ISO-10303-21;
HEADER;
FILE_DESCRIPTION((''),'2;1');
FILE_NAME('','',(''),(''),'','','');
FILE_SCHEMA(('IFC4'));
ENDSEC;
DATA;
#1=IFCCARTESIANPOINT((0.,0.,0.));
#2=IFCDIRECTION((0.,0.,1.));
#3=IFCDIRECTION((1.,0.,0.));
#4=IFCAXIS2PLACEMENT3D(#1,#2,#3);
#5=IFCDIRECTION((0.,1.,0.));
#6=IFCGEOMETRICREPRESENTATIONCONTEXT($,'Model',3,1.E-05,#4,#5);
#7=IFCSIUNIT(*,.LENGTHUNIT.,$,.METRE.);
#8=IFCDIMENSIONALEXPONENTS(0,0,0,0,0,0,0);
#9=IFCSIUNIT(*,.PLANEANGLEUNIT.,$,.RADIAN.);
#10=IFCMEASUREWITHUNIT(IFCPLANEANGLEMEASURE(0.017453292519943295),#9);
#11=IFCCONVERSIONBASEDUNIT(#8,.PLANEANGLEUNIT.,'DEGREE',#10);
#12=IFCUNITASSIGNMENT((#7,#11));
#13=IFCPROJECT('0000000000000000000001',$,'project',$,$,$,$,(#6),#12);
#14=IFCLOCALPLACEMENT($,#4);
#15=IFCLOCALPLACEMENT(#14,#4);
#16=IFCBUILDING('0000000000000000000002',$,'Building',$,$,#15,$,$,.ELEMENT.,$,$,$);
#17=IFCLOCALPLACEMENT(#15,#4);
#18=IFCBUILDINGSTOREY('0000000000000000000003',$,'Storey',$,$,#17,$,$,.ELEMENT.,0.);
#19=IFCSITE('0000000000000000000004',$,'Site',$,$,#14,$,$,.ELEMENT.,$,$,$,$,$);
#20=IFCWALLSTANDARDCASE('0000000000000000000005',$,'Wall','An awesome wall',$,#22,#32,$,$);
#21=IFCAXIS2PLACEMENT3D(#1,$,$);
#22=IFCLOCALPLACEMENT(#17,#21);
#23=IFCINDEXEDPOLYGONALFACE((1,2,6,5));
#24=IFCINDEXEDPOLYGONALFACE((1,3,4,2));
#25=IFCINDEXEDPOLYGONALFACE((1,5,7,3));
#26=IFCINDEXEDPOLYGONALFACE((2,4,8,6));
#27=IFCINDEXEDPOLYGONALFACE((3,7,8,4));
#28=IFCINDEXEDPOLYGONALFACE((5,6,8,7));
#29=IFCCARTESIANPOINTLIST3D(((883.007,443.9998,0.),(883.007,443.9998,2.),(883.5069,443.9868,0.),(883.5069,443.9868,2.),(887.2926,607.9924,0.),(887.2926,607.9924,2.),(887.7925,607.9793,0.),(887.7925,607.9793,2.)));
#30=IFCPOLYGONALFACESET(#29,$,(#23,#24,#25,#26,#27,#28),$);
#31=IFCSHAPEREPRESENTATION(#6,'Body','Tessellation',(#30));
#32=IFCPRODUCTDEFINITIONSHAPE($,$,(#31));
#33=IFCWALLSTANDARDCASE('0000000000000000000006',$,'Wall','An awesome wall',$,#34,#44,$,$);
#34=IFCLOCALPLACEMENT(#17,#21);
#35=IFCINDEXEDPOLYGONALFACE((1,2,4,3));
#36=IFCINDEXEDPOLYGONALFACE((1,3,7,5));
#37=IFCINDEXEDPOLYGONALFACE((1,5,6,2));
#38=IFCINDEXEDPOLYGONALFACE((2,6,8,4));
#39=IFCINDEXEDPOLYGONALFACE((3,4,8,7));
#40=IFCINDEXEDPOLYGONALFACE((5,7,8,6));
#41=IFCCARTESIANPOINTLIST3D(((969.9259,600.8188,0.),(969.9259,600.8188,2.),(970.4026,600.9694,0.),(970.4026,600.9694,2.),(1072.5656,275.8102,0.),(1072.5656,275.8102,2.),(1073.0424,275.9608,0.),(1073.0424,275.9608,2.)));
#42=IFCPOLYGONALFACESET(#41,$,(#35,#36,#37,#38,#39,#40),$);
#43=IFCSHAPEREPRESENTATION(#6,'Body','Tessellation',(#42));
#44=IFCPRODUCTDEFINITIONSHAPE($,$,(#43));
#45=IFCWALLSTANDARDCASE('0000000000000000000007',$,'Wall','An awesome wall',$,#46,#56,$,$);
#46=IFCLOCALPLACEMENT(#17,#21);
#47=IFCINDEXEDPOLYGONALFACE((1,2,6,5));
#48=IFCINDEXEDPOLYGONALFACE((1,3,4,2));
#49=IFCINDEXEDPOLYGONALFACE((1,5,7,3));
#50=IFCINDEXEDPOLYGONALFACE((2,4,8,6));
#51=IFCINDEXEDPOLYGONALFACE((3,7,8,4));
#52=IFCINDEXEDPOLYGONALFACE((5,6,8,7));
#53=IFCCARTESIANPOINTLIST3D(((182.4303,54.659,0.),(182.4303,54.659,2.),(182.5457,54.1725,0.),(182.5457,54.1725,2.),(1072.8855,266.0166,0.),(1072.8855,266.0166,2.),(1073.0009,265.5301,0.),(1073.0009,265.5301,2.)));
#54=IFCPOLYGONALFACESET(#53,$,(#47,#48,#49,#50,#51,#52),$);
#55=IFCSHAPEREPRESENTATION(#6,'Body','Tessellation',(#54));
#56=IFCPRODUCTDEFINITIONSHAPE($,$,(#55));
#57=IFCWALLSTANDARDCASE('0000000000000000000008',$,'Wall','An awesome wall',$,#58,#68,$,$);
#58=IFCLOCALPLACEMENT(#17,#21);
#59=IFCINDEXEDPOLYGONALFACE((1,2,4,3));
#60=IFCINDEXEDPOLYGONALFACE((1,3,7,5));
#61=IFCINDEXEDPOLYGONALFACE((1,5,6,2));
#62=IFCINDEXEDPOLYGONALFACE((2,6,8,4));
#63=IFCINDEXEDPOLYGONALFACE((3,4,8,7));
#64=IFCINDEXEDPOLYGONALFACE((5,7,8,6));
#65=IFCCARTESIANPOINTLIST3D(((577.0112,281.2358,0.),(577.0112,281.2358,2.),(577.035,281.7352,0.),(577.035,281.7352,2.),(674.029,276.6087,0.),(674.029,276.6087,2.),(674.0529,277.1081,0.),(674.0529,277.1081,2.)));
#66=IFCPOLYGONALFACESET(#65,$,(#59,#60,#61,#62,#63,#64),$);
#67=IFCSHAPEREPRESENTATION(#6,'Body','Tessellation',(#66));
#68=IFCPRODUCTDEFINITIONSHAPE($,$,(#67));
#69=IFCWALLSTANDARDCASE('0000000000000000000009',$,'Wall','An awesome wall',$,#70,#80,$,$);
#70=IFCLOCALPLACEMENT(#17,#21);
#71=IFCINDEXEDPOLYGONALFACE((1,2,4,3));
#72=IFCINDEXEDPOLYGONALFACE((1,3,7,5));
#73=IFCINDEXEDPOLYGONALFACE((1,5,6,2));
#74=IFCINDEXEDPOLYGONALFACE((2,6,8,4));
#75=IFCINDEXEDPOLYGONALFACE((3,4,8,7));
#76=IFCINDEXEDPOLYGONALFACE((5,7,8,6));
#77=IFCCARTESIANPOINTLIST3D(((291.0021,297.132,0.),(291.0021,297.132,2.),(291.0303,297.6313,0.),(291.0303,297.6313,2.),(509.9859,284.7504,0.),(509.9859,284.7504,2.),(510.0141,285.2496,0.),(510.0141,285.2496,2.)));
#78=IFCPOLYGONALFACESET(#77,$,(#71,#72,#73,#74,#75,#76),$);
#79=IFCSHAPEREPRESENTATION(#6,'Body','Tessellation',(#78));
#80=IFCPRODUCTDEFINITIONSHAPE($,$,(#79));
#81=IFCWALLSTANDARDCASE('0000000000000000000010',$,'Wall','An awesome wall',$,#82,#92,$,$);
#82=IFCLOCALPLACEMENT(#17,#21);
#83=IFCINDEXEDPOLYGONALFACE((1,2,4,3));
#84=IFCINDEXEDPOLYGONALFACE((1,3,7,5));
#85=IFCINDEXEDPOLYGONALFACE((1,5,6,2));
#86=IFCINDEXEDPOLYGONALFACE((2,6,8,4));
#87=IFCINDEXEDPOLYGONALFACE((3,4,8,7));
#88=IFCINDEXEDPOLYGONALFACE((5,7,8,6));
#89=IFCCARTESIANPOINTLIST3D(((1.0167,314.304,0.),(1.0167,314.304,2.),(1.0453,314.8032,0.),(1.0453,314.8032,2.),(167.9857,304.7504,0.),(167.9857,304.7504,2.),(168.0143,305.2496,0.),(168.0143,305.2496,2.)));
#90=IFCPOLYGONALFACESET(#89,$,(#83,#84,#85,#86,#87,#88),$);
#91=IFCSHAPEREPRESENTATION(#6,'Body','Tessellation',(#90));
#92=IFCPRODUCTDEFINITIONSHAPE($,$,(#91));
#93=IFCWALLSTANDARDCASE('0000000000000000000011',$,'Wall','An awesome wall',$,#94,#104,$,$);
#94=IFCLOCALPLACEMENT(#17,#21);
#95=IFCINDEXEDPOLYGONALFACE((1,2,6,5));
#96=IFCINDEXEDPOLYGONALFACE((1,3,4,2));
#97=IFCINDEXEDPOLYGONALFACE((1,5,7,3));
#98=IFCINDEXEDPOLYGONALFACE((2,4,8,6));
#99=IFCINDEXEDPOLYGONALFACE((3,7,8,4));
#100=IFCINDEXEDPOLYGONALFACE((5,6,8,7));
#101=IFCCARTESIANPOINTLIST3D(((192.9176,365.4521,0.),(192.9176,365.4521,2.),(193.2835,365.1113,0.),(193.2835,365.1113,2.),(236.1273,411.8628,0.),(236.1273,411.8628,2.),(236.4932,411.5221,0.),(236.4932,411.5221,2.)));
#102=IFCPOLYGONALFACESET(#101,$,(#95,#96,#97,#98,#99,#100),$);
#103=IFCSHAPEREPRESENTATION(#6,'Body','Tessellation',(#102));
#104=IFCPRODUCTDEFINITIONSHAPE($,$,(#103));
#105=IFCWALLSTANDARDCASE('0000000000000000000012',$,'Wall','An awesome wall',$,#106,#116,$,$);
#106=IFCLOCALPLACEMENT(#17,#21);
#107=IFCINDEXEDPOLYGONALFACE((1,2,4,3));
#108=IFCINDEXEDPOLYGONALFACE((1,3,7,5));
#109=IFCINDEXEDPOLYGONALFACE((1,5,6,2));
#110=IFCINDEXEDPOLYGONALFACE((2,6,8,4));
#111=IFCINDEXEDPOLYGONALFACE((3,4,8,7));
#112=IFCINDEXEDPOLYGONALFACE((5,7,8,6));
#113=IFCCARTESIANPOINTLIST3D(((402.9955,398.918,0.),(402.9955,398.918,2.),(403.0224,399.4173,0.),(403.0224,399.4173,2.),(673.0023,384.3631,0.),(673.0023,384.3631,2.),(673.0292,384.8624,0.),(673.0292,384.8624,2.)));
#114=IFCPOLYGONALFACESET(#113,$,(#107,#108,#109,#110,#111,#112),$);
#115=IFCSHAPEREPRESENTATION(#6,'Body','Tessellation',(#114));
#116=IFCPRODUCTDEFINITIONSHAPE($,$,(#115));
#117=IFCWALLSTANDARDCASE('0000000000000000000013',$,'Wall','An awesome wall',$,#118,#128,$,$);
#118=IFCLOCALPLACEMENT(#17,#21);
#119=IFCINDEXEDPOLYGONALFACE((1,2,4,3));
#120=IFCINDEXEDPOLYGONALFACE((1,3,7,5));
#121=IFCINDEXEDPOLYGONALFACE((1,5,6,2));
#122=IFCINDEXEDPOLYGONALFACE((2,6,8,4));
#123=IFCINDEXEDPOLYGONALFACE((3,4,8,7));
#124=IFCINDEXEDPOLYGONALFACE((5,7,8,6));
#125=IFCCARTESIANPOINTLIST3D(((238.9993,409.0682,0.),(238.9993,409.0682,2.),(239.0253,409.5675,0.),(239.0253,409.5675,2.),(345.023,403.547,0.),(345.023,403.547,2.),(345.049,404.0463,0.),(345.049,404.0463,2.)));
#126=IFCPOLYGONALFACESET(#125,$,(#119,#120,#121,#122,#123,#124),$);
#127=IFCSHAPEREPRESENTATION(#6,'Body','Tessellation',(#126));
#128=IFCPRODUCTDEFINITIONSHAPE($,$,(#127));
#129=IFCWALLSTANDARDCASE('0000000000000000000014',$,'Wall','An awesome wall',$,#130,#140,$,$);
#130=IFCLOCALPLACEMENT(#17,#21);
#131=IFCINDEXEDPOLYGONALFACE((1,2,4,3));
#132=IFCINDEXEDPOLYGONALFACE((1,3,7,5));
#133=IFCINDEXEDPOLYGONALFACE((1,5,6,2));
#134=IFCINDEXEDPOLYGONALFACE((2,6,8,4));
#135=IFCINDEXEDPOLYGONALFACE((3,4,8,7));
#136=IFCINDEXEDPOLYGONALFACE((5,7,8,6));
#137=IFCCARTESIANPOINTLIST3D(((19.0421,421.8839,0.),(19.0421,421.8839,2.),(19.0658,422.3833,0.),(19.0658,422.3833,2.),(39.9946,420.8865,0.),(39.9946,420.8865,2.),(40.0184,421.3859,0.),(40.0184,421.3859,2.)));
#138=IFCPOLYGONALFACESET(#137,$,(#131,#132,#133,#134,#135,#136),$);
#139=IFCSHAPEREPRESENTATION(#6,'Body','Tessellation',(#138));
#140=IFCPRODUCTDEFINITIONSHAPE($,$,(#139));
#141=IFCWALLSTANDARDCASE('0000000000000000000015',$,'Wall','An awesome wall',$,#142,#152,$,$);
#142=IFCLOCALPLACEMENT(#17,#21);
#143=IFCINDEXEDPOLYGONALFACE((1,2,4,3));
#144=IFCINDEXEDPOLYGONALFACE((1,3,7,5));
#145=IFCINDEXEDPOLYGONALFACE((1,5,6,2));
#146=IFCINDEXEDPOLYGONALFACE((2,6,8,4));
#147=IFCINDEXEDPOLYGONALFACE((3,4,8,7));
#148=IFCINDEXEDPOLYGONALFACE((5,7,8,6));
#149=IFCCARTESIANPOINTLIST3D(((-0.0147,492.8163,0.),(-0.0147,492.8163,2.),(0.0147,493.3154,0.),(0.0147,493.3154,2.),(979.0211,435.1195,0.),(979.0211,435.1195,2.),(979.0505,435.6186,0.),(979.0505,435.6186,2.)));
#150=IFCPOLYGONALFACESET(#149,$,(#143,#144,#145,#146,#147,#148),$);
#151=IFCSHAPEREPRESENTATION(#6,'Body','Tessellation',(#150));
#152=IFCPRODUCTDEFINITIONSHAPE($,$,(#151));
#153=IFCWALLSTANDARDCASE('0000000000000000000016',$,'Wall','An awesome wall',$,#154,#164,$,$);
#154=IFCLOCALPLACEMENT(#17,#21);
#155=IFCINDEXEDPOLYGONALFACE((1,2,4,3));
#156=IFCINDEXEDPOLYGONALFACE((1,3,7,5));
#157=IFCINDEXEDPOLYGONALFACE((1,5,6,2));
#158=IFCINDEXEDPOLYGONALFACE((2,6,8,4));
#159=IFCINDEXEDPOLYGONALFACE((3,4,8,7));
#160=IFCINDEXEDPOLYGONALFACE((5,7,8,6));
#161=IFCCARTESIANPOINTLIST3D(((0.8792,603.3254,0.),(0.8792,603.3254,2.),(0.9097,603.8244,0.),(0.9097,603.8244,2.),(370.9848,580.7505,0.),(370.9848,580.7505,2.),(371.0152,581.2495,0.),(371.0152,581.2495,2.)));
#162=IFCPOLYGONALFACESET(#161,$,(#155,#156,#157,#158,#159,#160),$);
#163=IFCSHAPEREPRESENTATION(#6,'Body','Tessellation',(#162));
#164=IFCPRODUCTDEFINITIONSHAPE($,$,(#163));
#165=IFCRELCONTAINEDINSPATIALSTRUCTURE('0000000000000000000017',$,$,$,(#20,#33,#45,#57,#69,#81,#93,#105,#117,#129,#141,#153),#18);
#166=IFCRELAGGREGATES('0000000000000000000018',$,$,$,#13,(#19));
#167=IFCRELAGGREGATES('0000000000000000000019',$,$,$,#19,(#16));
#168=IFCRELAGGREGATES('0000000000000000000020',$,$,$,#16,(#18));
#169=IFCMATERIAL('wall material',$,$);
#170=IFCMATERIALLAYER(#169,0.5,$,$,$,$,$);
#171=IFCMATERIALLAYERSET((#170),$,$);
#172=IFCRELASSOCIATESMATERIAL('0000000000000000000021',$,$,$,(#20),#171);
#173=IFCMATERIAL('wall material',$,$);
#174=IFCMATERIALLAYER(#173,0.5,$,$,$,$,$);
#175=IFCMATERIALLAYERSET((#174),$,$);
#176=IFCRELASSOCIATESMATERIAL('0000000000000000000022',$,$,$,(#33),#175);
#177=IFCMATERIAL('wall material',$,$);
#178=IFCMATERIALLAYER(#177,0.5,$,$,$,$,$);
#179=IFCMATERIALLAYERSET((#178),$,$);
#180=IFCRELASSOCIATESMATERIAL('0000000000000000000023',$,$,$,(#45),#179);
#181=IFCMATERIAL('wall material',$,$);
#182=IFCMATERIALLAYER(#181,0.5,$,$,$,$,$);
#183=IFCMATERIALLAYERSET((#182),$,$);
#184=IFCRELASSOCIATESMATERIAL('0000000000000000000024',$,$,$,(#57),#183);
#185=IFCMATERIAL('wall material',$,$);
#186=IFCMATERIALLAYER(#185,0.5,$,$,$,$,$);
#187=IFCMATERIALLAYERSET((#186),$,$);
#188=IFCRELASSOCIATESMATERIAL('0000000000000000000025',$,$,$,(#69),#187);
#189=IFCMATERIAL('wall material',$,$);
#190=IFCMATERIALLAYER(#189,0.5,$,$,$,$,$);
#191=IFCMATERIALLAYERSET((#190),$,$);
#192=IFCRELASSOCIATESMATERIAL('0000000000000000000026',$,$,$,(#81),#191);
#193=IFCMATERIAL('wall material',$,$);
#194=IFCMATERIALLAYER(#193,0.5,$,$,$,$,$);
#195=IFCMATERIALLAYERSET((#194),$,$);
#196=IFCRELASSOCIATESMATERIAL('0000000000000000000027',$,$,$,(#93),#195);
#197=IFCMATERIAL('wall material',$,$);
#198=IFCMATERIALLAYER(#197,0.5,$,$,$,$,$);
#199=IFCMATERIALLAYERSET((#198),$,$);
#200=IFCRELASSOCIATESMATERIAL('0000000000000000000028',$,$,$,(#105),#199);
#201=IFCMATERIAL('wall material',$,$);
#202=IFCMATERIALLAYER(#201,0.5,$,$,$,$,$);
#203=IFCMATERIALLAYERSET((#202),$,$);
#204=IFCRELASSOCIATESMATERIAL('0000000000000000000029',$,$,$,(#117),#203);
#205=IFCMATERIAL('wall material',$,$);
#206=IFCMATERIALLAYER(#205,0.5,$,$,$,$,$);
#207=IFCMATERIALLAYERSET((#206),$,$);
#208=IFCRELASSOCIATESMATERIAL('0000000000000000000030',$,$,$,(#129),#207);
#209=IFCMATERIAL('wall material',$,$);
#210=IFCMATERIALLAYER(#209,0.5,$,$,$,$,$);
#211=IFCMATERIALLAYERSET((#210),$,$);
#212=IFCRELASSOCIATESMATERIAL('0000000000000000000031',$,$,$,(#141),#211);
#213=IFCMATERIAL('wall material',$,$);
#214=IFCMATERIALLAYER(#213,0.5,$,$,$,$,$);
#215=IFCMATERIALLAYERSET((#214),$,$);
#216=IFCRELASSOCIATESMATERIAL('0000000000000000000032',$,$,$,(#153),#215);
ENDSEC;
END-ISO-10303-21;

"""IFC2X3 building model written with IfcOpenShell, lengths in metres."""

from ifc_helpers import new_model, entity, si_unit, converted_unit, direction, frame, origin_with_axes, place, context, project, spatial, polyline, outline, extrude, material, layer, layer_set, layer_usage, element, save


model = new_model("IFC2X3")

# Units and contexts
model_context = context("Model", 3, precision=1e-05, world=origin_with_axes(), true_north=direction((0.0, 1.0, 0.0)))
ifc_project = project(units=[si_unit("LENGTHUNIT", "METRE"), converted_unit("PLANEANGLEUNIT", "DEGREE", entity("IfcPlaneAngleMeasure", 0.017453292519943295), si_unit("PLANEANGLEUNIT", "RADIAN"), dimensions=[0, 0, 0, 0, 0, 0, 0])], contexts=[model_context])

# Site, building, storey
site_placement = place(None, origin_with_axes())
site = spatial("IfcSite", under=ifc_project, at=site_placement, Name="Site", CompositionType="ELEMENT")
building_placement = place(site_placement, origin_with_axes())
building = spatial("IfcBuilding", under=site, at=building_placement, Name="Building", CompositionType="ELEMENT")
storey_placement = place(building_placement, origin_with_axes())
storey = spatial("IfcBuildingStorey", under=building, at=storey_placement, Name="Storey", CompositionType="ELEMENT", Elevation=0.0)

# Walls
ifc_material_1 = material(Name="wall material")
ifc_layer_1 = layer(ifc_material_1, 0.5)
ifc_layer_set_1 = layer_set([ifc_layer_1])
ifc_layer_usage_1 = layer_usage(ifc_layer_set_1, "AXIS2", "POSITIVE", -0.1)
wall_1_placement = place(storey_placement, origin_with_axes())
element("IfcWallStandardCase", 1, at=wall_1_placement, inside=storey, material=ifc_layer_usage_1, Name="Wall", Description="An awesome wall", context=model_context, shape_type="SweptSolid", body=[
    extrude(outline(polyline([(0.0, -0.25, 0.0), (164.0485, -0.25, 0.0), (164.0485, 0.25, 0.0), (0.0, 0.25, 0.0), (0.0, -0.25, 0.0)])), frame((883.257, 443.9933, 0.0), z_axis=(0.0, 0.0, 1.0), x_axis=(4.28558, 163.99254, 0.0)), (0.0, 0.0, 1.0), 2.0),
])
ifc_material_2 = material(Name="wall material")
ifc_layer_2 = layer(ifc_material_2, 0.5)
ifc_layer_set_2 = layer_set([ifc_layer_2])
ifc_layer_usage_2 = layer_usage(ifc_layer_set_2, "AXIS2", "POSITIVE", -0.1)
wall_2_placement = place(storey_placement, origin_with_axes())
element("IfcWallStandardCase", 2, at=wall_2_placement, inside=storey, material=ifc_layer_usage_2, Name="Wall", Description="An awesome wall", context=model_context, shape_type="SweptSolid", body=[
    extrude(outline(polyline([(0.0, -0.25, 0.0), (340.8306, -0.25, 0.0), (340.8306, 0.25, 0.0), (0.0, 0.25, 0.0), (0.0, -0.25, 0.0)])), frame((1072.804, 275.8855, 0.0), z_axis=(0.0, 0.0, 1.0), x_axis=(-102.63975, 325.00857, 0.0)), (0.0, 0.0, 1.0), 2.0),
])
ifc_material_3 = material(Name="wall material")
ifc_layer_3 = layer(ifc_material_3, 0.5)
ifc_layer_set_3 = layer_set([ifc_layer_3])
ifc_layer_usage_3 = layer_usage(ifc_layer_set_3, "AXIS2", "POSITIVE", -0.1)
wall_3_placement = place(storey_placement, origin_with_axes())
element("IfcWallStandardCase", 3, at=wall_3_placement, inside=storey, material=ifc_layer_usage_3, Name="Wall", Description="An awesome wall", context=model_context, shape_type="SweptSolid", body=[
    extrude(outline(polyline([(0.0, -0.25, 0.0), (915.1953, -0.25, 0.0), (915.1953, 0.25, 0.0), (0.0, 0.25, 0.0), (0.0, -0.25, 0.0)])), frame((182.488, 54.4158, 0.0), z_axis=(0.0, 0.0, 1.0), x_axis=(890.4552, 211.35757, 0.0)), (0.0, 0.0, 1.0), 2.0),
])
ifc_material_4 = material(Name="wall material")
ifc_layer_4 = layer(ifc_material_4, 0.5)
ifc_layer_set_4 = layer_set([ifc_layer_4])
ifc_layer_usage_4 = layer_usage(ifc_layer_set_4, "AXIS2", "POSITIVE", -0.1)
wall_4_placement = place(storey_placement, origin_with_axes())
element("IfcWallStandardCase", 4, at=wall_4_placement, inside=storey, material=ifc_layer_usage_4, Name="Wall", Description="An awesome wall", context=model_context, shape_type="SweptSolid", body=[
    extrude(outline(polyline([(0.0, -0.25, 0.0), (97.1281, -0.25, 0.0), (97.1281, 0.25, 0.0), (0.0, 0.25, 0.0), (0.0, -0.25, 0.0)])), frame((674.0409, 276.8584, 0.0), z_axis=(0.0, 0.0, 1.0), x_axis=(-97.01782, 4.62707, 0.0)), (0.0, 0.0, 1.0), 2.0),
])
ifc_material_5 = material(Name="wall material")
ifc_layer_5 = layer(ifc_material_5, 0.5)
ifc_layer_set_5 = layer_set([ifc_layer_5])
ifc_layer_usage_5 = layer_usage(ifc_layer_set_5, "AXIS2", "POSITIVE", -0.1)
wall_5_placement = place(storey_placement, origin_with_axes())
element("IfcWallStandardCase", 5, at=wall_5_placement, inside=storey, material=ifc_layer_usage_5, Name="Wall", Description="An awesome wall", context=model_context, shape_type="SweptSolid", body=[
    extrude(outline(polyline([(0.0, -0.25, 0.0), (219.3336, -0.25, 0.0), (219.3336, 0.25, 0.0), (0.0, 0.25, 0.0), (0.0, -0.25, 0.0)])), frame((510.0, 285.0, 0.0), z_axis=(0.0, 0.0, 1.0), x_axis=(-218.9838, 12.38165, 0.0)), (0.0, 0.0, 1.0), 2.0),
])
ifc_material_6 = material(Name="wall material")
ifc_layer_6 = layer(ifc_material_6, 0.5)
ifc_layer_set_6 = layer_set([ifc_layer_6])
ifc_layer_usage_6 = layer_usage(ifc_layer_set_6, "AXIS2", "POSITIVE", -0.1)
wall_6_placement = place(storey_placement, origin_with_axes())
element("IfcWallStandardCase", 6, at=wall_6_placement, inside=storey, material=ifc_layer_usage_6, Name="Wall", Description="An awesome wall", context=model_context, shape_type="SweptSolid", body=[
    extrude(outline(polyline([(0.0, -0.25, 0.0), (167.2421, -0.25, 0.0), (167.2421, 0.25, 0.0), (0.0, 0.25, 0.0), (0.0, -0.25, 0.0)])), frame((168.0, 305.0, 0.0), z_axis=(0.0, 0.0, 1.0), x_axis=(-166.96902, 9.55356, 0.0)), (0.0, 0.0, 1.0), 2.0),
])
ifc_material_7 = material(Name="wall material")
ifc_layer_7 = layer(ifc_material_7, 0.5)
ifc_layer_set_7 = layer_set([ifc_layer_7])
ifc_layer_usage_7 = layer_usage(ifc_layer_set_7, "AXIS2", "POSITIVE", -0.1)
wall_7_placement = place(storey_placement, origin_with_axes())
element("IfcWallStandardCase", 7, at=wall_7_placement, inside=storey, material=ifc_layer_usage_7, Name="Wall", Description="An awesome wall", context=model_context, shape_type="SweptSolid", body=[
    extrude(outline(polyline([(0.0, -0.25, 0.0), (63.4116, -0.25, 0.0), (63.4116, 0.25, 0.0), (0.0, 0.25, 0.0), (0.0, -0.25, 0.0)])), frame((193.1006, 365.2817, 0.0), z_axis=(0.0, 0.0, 1.0), x_axis=(43.20971, 46.41074, 0.0)), (0.0, 0.0, 1.0), 2.0),
])
ifc_material_8 = material(Name="wall material")
ifc_layer_8 = layer(ifc_material_8, 0.5)
ifc_layer_set_8 = layer_set([ifc_layer_8])
ifc_layer_usage_8 = layer_usage(ifc_layer_set_8, "AXIS2", "POSITIVE", -0.1)
wall_8_placement = place(storey_placement, origin_with_axes())
element("IfcWallStandardCase", 8, at=wall_8_placement, inside=storey, material=ifc_layer_usage_8, Name="Wall", Description="An awesome wall", context=model_context, shape_type="SweptSolid", body=[
    extrude(outline(polyline([(0.0, -0.25, 0.0), (270.3988, -0.25, 0.0), (270.3988, 0.25, 0.0), (0.0, 0.25, 0.0), (0.0, -0.25, 0.0)])), frame((673.0158, 384.6127, 0.0), z_axis=(0.0, 0.0, 1.0), x_axis=(-270.00681, 14.5549, 0.0)), (0.0, 0.0, 1.0), 2.0),
])
ifc_material_9 = material(Name="wall material")
ifc_layer_9 = layer(ifc_material_9, 0.5)
ifc_layer_set_9 = layer_set([ifc_layer_9])
ifc_layer_usage_9 = layer_usage(ifc_layer_set_9, "AXIS2", "POSITIVE", -0.1)
wall_9_placement = place(storey_placement, origin_with_axes())
element("IfcWallStandardCase", 9, at=wall_9_placement, inside=storey, material=ifc_layer_usage_9, Name="Wall", Description="An awesome wall", context=model_context, shape_type="SweptSolid", body=[
    extrude(outline(polyline([(0.0, -0.25, 0.0), (106.1673, -0.25, 0.0), (106.1673, 0.25, 0.0), (0.0, 0.25, 0.0), (0.0, -0.25, 0.0)])), frame((345.036, 403.7967, 0.0), z_axis=(0.0, 0.0, 1.0), x_axis=(-106.02367, 5.52118, 0.0)), (0.0, 0.0, 1.0), 2.0),
])
ifc_material_10 = material(Name="wall material")
ifc_layer_10 = layer(ifc_material_10, 0.5)
ifc_layer_set_10 = layer_set([ifc_layer_10])
ifc_layer_usage_10 = layer_usage(ifc_layer_set_10, "AXIS2", "POSITIVE", -0.1)
wall_10_placement = place(storey_placement, origin_with_axes())
element("IfcWallStandardCase", 10, at=wall_10_placement, inside=storey, material=ifc_layer_usage_10, Name="Wall", Description="An awesome wall", context=model_context, shape_type="SweptSolid", body=[
    extrude(outline(polyline([(0.0, -0.25, 0.0), (20.9762, -0.25, 0.0), (20.9762, 0.25, 0.0), (0.0, 0.25, 0.0), (0.0, -0.25, 0.0)])), frame((19.054, 422.1336, 0.0), z_axis=(0.0, 0.0, 1.0), x_axis=(20.952526, -0.99735, 0.0)), (0.0, 0.0, 1.0), 2.0),
])
ifc_material_11 = material(Name="wall material")
ifc_layer_11 = layer(ifc_material_11, 0.5)
ifc_layer_set_11 = layer_set([ifc_layer_11])
ifc_layer_usage_11 = layer_usage(ifc_layer_set_11, "AXIS2", "POSITIVE", -0.1)
wall_11_placement = place(storey_placement, origin_with_axes())
element("IfcWallStandardCase", 11, at=wall_11_placement, inside=storey, material=ifc_layer_usage_11, Name="Wall", Description="An awesome wall", context=model_context, shape_type="SweptSolid", body=[
    extrude(outline(polyline([(0.0, -0.25, 0.0), (980.7344, -0.25, 0.0), (980.7344, 0.25, 0.0), (0.0, 0.25, 0.0), (0.0, -0.25, 0.0)])), frame((979.0358, 435.369, 0.0), z_axis=(0.0, 0.0, 1.0), x_axis=(-979.0358, 57.69684, 0.0)), (0.0, 0.0, 1.0), 2.0),
])
ifc_material_12 = material(Name="wall material")
ifc_layer_12 = layer(ifc_material_12, 0.5)
ifc_layer_set_12 = layer_set([ifc_layer_12])
ifc_layer_usage_12 = layer_usage(ifc_layer_set_12, "AXIS2", "POSITIVE", -0.1)
wall_12_placement = place(storey_placement, origin_with_axes())
element("IfcWallStandardCase", 12, at=wall_12_placement, inside=storey, material=ifc_layer_usage_12, Name="Wall", Description="An awesome wall", context=model_context, shape_type="SweptSolid", body=[
    extrude(outline(polyline([(0.0, -0.25, 0.0), (370.7934, -0.25, 0.0), (370.7934, 0.25, 0.0), (0.0, 0.25, 0.0), (0.0, -0.25, 0.0)])), frame((371.0, 581.0, 0.0), z_axis=(0.0, 0.0, 1.0), x_axis=(-370.105534, 22.5749, 0.0)), (0.0, 0.0, 1.0), 2.0),
])

save(model, "model.ifc")
